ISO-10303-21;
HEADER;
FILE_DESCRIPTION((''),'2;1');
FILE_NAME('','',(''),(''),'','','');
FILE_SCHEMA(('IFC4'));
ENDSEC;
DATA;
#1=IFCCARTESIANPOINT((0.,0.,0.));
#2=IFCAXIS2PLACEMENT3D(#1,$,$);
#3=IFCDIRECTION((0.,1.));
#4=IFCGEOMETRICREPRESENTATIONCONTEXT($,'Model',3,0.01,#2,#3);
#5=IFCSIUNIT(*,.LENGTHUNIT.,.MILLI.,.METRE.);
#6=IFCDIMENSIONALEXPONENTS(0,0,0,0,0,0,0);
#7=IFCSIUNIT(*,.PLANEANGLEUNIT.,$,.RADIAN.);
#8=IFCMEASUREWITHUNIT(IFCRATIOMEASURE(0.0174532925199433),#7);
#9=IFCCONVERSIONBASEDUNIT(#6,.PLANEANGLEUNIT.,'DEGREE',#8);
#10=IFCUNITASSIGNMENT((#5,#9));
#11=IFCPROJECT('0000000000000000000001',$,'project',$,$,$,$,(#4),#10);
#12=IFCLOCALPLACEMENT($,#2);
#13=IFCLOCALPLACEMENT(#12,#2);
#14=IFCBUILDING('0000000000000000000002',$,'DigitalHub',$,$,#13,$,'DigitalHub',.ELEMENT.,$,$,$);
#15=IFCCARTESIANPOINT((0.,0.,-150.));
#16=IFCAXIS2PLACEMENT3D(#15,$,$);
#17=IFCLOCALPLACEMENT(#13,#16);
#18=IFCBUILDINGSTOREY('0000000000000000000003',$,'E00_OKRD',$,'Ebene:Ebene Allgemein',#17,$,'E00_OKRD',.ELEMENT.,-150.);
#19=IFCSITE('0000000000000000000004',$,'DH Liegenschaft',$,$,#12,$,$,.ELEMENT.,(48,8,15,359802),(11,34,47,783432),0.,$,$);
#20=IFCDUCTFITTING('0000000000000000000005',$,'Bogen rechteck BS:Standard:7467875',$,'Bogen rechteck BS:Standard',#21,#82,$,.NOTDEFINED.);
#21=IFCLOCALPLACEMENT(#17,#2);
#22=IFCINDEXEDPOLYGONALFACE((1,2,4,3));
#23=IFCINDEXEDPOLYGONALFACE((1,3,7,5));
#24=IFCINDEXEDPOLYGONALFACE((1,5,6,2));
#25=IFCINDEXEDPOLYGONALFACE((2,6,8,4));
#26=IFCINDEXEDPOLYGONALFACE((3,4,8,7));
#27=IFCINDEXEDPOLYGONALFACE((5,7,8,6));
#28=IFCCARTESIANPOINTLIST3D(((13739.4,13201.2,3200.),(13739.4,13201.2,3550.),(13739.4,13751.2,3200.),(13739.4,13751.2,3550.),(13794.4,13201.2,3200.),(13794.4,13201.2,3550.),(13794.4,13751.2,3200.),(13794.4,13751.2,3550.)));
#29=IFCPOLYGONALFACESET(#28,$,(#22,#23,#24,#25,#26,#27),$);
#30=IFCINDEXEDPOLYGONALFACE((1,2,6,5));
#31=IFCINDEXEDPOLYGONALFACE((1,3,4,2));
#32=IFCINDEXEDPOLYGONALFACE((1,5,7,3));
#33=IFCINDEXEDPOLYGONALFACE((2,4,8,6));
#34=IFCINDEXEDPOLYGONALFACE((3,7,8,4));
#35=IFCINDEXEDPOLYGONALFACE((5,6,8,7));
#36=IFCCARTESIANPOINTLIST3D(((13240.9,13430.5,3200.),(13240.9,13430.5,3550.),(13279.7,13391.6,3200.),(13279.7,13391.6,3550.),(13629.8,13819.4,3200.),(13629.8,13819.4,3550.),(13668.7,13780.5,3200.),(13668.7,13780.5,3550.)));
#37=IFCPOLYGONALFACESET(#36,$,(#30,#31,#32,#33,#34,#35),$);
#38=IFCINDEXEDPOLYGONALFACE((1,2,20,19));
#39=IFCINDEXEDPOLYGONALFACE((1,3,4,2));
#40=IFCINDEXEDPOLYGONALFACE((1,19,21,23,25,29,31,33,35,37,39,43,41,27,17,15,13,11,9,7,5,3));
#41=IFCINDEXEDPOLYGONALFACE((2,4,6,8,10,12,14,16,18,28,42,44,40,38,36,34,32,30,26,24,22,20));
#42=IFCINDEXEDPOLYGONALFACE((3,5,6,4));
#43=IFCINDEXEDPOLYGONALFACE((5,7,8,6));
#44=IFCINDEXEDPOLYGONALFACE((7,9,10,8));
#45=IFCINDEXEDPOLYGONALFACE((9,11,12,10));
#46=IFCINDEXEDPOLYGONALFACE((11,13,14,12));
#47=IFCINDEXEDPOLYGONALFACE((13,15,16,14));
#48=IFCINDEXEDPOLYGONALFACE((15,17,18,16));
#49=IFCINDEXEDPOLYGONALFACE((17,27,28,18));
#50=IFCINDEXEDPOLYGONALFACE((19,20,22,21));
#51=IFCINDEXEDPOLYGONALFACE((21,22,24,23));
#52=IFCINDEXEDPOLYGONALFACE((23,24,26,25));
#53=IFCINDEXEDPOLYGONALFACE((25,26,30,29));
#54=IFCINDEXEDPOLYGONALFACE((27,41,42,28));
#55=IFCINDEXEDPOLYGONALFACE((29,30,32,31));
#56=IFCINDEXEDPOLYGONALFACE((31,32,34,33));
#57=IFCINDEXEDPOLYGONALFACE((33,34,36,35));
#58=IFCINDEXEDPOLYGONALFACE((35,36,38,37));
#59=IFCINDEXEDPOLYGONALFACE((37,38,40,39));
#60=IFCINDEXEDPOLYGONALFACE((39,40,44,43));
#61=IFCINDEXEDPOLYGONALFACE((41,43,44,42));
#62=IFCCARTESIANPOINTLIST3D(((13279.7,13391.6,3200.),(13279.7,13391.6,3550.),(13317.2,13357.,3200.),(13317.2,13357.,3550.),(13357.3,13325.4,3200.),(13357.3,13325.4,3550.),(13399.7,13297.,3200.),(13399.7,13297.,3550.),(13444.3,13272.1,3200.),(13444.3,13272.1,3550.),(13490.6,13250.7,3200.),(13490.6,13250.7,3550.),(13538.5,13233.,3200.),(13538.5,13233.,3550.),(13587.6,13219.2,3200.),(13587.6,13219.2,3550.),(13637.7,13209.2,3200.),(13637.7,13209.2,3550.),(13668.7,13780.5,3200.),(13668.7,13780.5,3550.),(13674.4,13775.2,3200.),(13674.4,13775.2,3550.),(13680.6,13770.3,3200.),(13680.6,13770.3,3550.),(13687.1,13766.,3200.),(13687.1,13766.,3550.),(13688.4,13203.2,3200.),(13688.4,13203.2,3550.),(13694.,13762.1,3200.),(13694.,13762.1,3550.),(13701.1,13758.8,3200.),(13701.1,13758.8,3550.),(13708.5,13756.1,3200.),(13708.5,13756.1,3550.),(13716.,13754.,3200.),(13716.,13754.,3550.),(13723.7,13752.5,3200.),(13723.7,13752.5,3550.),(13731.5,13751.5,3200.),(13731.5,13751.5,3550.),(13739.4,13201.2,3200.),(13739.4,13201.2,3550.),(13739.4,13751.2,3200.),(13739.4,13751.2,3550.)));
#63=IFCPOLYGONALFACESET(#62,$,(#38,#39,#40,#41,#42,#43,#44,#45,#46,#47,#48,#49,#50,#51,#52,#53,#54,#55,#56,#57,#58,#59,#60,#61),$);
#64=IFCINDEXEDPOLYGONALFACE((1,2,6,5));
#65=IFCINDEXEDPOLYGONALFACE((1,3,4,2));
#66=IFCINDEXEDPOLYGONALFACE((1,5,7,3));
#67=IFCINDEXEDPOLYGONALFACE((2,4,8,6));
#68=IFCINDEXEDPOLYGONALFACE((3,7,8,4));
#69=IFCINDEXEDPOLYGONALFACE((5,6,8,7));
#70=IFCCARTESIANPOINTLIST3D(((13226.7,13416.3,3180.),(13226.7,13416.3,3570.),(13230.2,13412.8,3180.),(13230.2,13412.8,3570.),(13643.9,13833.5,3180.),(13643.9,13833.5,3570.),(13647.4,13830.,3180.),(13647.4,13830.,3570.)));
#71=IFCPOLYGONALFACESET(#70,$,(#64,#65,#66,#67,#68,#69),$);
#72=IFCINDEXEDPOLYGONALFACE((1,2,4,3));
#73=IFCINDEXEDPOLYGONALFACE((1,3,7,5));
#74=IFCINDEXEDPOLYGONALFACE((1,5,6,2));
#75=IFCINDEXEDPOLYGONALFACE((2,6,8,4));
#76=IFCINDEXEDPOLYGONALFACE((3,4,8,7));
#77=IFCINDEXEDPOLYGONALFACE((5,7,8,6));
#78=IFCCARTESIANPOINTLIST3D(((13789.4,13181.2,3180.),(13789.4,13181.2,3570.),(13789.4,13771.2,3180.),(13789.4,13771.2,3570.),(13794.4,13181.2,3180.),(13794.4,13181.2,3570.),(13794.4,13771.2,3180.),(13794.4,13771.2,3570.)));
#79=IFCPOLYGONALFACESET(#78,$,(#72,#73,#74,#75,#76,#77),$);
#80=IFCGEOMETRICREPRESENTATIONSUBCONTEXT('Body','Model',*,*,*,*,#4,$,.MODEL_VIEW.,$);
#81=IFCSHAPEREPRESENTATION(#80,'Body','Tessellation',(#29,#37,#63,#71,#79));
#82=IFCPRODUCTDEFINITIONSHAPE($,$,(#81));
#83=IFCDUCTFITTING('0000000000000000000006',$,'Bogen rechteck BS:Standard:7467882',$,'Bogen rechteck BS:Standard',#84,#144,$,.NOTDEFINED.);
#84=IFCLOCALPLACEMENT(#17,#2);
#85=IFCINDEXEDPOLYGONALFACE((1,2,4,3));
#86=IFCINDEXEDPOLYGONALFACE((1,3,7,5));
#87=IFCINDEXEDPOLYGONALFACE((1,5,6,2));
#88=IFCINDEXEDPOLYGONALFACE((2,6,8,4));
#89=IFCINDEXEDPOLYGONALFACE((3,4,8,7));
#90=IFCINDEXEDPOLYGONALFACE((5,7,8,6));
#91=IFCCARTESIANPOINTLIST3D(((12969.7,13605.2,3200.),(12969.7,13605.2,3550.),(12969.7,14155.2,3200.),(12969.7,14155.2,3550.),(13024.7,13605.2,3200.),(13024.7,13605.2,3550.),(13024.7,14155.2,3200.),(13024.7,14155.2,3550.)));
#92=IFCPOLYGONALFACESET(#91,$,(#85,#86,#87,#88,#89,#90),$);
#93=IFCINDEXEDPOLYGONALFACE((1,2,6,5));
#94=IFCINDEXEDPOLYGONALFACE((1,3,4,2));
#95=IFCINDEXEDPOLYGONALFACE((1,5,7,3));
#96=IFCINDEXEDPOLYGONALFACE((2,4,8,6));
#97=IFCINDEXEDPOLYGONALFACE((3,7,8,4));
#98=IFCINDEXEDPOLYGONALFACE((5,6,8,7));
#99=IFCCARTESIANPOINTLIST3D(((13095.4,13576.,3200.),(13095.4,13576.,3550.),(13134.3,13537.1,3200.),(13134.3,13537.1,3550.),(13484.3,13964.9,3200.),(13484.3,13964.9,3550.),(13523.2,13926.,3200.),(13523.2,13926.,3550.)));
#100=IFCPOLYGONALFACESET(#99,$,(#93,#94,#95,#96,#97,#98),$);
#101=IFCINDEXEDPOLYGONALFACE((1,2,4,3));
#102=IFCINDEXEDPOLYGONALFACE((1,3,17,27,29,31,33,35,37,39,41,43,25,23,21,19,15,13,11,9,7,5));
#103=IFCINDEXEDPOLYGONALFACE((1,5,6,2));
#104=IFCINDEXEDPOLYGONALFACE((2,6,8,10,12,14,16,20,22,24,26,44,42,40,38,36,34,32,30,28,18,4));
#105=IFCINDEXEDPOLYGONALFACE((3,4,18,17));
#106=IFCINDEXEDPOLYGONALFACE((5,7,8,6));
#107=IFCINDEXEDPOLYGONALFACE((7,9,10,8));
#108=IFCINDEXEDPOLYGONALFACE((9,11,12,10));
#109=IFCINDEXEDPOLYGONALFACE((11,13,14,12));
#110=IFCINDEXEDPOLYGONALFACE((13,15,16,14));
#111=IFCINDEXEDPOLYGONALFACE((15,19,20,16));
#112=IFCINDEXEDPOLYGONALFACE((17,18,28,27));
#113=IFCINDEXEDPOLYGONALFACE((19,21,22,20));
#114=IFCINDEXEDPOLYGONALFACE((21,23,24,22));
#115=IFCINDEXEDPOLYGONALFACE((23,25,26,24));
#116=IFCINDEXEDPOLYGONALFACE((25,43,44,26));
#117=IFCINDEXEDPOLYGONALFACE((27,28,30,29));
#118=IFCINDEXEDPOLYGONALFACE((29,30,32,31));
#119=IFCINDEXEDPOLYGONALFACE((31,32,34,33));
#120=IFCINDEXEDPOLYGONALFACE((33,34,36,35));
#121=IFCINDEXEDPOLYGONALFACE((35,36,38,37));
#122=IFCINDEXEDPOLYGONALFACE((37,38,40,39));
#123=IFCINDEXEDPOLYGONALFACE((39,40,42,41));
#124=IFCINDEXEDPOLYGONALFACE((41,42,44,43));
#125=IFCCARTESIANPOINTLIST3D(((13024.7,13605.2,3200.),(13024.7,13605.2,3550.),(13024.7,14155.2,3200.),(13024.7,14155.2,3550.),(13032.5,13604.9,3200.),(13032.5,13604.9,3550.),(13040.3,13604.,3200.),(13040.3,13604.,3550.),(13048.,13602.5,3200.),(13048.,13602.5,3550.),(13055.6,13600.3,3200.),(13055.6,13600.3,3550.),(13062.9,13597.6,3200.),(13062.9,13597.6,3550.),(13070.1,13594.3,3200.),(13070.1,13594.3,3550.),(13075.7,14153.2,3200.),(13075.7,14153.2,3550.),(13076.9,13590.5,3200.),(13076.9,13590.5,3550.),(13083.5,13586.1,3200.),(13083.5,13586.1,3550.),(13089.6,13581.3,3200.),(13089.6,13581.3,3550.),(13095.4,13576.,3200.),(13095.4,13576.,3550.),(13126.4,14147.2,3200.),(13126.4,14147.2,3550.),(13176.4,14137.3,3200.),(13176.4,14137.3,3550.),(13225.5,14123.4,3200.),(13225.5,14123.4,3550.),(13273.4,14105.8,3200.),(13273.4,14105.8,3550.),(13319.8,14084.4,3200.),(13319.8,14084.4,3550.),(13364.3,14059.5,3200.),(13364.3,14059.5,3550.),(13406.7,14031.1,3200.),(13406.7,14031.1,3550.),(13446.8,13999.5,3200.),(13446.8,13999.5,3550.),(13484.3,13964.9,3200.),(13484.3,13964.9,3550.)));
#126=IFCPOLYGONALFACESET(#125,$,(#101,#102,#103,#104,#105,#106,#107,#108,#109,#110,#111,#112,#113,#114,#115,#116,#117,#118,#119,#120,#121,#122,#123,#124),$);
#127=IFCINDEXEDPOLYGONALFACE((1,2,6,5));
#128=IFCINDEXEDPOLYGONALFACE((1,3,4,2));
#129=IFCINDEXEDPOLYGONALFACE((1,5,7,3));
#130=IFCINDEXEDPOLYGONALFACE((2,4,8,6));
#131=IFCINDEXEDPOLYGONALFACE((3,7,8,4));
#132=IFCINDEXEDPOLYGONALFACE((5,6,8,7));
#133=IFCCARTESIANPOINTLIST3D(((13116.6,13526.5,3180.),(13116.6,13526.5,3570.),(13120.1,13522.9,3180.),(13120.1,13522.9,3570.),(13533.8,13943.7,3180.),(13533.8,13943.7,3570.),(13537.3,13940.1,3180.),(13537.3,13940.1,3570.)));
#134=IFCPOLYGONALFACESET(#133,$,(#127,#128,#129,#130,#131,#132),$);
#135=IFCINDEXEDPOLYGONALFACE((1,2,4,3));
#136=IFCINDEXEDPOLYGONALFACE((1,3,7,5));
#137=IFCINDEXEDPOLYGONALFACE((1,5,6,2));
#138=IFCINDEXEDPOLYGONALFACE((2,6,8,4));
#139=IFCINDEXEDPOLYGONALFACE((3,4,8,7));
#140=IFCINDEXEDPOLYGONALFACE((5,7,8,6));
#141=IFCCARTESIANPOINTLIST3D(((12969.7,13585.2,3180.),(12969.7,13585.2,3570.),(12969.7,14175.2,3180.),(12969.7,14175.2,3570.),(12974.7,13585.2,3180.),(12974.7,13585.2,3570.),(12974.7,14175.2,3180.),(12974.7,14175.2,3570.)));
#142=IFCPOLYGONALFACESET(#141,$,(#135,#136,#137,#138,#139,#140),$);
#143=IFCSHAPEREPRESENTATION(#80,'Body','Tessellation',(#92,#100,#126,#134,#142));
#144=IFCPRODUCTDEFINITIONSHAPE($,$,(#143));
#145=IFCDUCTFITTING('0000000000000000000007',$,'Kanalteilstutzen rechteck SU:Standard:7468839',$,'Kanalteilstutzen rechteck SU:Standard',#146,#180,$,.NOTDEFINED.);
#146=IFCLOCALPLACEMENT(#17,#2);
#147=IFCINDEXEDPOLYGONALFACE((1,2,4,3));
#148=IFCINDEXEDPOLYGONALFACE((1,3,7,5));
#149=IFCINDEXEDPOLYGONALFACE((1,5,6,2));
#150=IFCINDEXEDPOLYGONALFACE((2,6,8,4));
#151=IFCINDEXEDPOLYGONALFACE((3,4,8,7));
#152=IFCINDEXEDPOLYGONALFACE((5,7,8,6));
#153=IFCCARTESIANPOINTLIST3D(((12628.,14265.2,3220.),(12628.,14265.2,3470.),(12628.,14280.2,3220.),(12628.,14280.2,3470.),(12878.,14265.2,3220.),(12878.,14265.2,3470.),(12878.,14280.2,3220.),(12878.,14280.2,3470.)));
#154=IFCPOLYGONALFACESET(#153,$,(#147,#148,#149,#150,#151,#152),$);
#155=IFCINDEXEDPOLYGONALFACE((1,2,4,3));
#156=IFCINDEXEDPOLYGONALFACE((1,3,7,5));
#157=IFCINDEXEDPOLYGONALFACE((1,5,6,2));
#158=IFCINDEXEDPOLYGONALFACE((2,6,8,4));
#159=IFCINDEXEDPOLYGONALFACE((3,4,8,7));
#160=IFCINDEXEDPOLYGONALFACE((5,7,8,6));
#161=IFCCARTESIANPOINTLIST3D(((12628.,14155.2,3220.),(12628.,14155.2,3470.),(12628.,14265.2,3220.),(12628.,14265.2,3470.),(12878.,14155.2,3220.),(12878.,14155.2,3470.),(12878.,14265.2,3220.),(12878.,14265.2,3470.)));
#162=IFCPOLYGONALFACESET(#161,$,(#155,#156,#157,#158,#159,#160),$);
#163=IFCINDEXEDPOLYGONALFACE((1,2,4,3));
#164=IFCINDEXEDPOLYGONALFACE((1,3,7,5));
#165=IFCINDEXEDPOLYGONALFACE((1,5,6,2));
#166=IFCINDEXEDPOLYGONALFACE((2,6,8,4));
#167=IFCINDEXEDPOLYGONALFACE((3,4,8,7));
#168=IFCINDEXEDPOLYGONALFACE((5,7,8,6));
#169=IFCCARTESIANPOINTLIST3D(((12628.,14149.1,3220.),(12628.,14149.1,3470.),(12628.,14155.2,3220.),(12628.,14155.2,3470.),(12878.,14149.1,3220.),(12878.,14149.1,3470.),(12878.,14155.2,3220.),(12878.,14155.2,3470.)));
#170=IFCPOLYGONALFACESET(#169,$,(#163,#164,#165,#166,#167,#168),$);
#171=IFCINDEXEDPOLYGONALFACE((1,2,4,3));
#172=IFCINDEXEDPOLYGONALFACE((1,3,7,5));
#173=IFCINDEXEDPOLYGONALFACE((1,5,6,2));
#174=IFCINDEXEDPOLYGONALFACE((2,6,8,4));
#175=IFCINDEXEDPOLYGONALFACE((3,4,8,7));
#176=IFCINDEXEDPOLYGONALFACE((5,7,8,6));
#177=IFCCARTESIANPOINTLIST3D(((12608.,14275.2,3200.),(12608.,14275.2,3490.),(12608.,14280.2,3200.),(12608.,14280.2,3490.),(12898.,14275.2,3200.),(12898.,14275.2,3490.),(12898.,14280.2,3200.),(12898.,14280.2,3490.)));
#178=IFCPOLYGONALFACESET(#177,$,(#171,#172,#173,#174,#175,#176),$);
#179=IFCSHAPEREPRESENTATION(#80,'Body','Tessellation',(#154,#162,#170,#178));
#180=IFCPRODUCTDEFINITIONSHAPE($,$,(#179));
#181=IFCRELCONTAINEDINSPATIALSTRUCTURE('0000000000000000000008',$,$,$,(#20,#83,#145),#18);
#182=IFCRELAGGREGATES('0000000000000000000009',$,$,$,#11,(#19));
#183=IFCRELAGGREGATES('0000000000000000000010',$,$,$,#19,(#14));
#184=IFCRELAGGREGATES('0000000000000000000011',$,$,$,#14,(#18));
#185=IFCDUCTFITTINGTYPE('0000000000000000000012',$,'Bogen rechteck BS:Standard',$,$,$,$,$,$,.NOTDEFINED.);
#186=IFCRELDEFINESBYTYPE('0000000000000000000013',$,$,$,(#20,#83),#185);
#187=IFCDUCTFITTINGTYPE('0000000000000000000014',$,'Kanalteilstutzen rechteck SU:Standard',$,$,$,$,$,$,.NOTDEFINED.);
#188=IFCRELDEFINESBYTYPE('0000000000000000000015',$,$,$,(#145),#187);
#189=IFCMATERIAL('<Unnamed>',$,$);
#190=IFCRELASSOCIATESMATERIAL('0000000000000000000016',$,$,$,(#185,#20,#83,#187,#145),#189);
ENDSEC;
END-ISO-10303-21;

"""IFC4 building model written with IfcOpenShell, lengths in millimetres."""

from ifc_helpers import new_model, entity, si_unit, converted_unit, direction, frame, origin, place, context, subcontext, project, spatial, indexed_curve, outline, extrude, source, transform, mapped, material, type_object, type_shapes, element, save


model = new_model("IFC4")

# Units and contexts
model_context = context("Model", 3, precision=0.01, world=origin(), true_north=direction((0.0, 1.0)))
body_context = subcontext(model_context, "Body", "Model", "MODEL_VIEW")
ifc_project = project(units=[si_unit("LENGTHUNIT", "METRE", prefix="MILLI"), converted_unit("PLANEANGLEUNIT", "DEGREE", entity("IfcRatioMeasure", 0.0174532925199433), si_unit("PLANEANGLEUNIT", "RADIAN"), dimensions=[0, 0, 0, 0, 0, 0, 0])], contexts=[model_context])

# Site, building, storey
site_placement = place(None, origin())
site = spatial("IfcSite", under=ifc_project, at=site_placement, Name="DH Liegenschaft", CompositionType="ELEMENT", RefLatitude=(48, 8, 15, 359802), RefLongitude=(11, 34, 47, 783432), RefElevation=0.0)
building_placement = place(site_placement, origin())
building = spatial("IfcBuilding", under=site, at=building_placement, Name="DigitalHub", LongName="DigitalHub", CompositionType="ELEMENT")
storey_placement = place(building_placement, frame((0.0, 0.0, -150.0)))
storey = spatial("IfcBuildingStorey", under=building, at=storey_placement, Name="E00_OKRD", ObjectType="Ebene:Ebene Allgemein", LongName="E00_OKRD", CompositionType="ELEMENT", Elevation=-150.0)

# Shared definitions
ifc_material_1 = material(Name="<Unnamed>")

# Duct fittings
duct_fitting_type_1 = type_object("IfcDuctFittingType", Name="Bogen rechteck BS:Standard", PredefinedType="NOTDEFINED", material=ifc_material_1)
shared_shape_1 = source(origin(), body_context, "Body", "SweptSolid", [
    extrude(outline(indexed_curve([(-27.5, -275.0), (27.5, -275.0), (27.5, 275.0), (-27.5, 275.0), (-27.5, -275.0)], self_intersect=False)), frame((129.3, 129.3, -175.0), z_axis=(0.0, 0.0, 1.0), x_axis=(0.707107, 0.707107, 0.0)), (0.0, 0.0, 1.0), 350.0),
    extrude(outline(indexed_curve([(-275.0, -27.5), (275.0, -27.5), (275.0, 27.5), (-275.0, 27.5), (-275.0, -27.5)], self_intersect=False)), frame((-182.8, 0.0, -175.0), z_axis=(0.0, 0.0, 1.0), x_axis=(0.0, -1.0, 0.0)), (0.0, 0.0, 1.0), 350.0),
    extrude(outline(indexed_curve([(-329.9, -132.6), (220.1, -132.6), (220.4, -124.7), (221.3, -116.9), (222.8, -109.2), (225.0, -101.7), (227.7, -94.3), (231.0, -87.2), (234.8, -80.3), (239.2, -73.8), (244.0, -67.6), (249.4, -61.9), (-139.5, 327.0), (-174.2, 289.6), (-205.8, 249.5), (-234.1, 207.0), (-259.1, 162.5), (-280.4, 116.2), (-298.1, 68.3), (-312.0, 19.2), (-321.9, -30.9), (-327.9, -81.6), (-329.9, -132.6)], self_intersect=False)), frame((-22.7, 54.9, -175.0), z_axis=(0.0, 0.0, 1.0), x_axis=(-0.707107, 0.707107, 0.0)), (0.0, 0.0, 1.0), 350.0),
    extrude(outline(indexed_curve([(-2.5, -295.0), (2.5, -295.0), (2.5, 295.0), (-2.5, 295.0), (-2.5, -295.0)], self_intersect=False)), frame((-207.8, 0.0, -195.0)), (0.0, 0.0, 1.0), 390.0),
    extrude(outline(indexed_curve([(-2.5, -295.0), (2.5, -295.0), (2.5, 295.0), (-2.5, 295.0), (-2.5, -295.0)], self_intersect=False)), frame((147.0, 147.0, -195.0), z_axis=(0.0, 0.0, 1.0), x_axis=(0.707107, 0.707107, 0.0)), (0.0, 0.0, 1.0), 390.0),
])
type_shapes(duct_fitting_type_1, [shared_shape_1])
for number, where, z_axis, x_axis, name in (
    (1, (13584.0, 13476.2, 3375.0), (0.0, 0.0, 1.0), (0.707107, -0.707107, 0.0), "Bogen rechteck BS:Standard:7467875"),
    (2, (13180.0, 13880.2, 3375.0), (0.0, 0.0, 1.0), (-0.707107, 0.707107, 0.0), "Bogen rechteck BS:Standard:7467882"),
):
    element("IfcDuctFitting", number, at=place(storey_placement, frame(where, z_axis=z_axis, x_axis=x_axis)), inside=storey, type_object=duct_fitting_type_1, material=ifc_material_1, Name=name, ObjectType="Bogen rechteck BS:Standard", PredefinedType="NOTDEFINED", context=body_context, shape_type="MappedRepresentation", body=[
        mapped(shared_shape_1, transform((0.0, 0.0, 0.0), scale=1.0)),
    ])
duct_fitting_type_2 = type_object("IfcDuctFittingType", Name="Kanalteilstutzen rechteck SU:Standard", PredefinedType="NOTDEFINED", material=ifc_material_1)
shared_shape_2 = source(origin(), body_context, "Body", "SweptSolid", [
    extrude(outline(indexed_curve([(-7.5, -125.0), (7.5, -125.0), (7.5, 125.0), (-7.5, 125.0), (-7.5, -125.0)], self_intersect=False)), frame((117.5, 0.0, -125.0)), (0.0, 0.0, 1.0), 250.0),
    extrude(outline(indexed_curve([(-55.0, -125.0), (55.0, -125.0), (55.0, 125.0), (-55.0, 125.0), (-55.0, -125.0)], self_intersect=False)), frame((55.0, 0.0, -125.0)), (0.0, 0.0, 1.0), 250.0),
    extrude(outline(indexed_curve([(-3.0, -125.0), (3.0, -125.0), (3.0, 125.0), (-3.0, 125.0), (-3.0, -125.0)], self_intersect=False)), frame((-3.0, 0.0, -125.0)), (0.0, 0.0, 1.0), 250.0),
    extrude(outline(indexed_curve([(-2.5, -145.0), (2.5, -145.0), (2.5, 145.0), (-2.5, 145.0), (-2.5, -145.0)], self_intersect=False)), frame((122.5, 0.0, -145.0)), (0.0, 0.0, 1.0), 290.0),
])
type_shapes(duct_fitting_type_2, [shared_shape_2])
duct_fitting_1_placement = place(storey_placement, frame((12753.0, 14155.2, 3345.0), z_axis=(0.0, 0.0, -1.0), x_axis=(0.0, 1.0, 0.0)))
element("IfcDuctFitting", 3, at=duct_fitting_1_placement, inside=storey, type_object=duct_fitting_type_2, material=ifc_material_1, Name="Kanalteilstutzen rechteck SU:Standard:7468839", ObjectType="Kanalteilstutzen rechteck SU:Standard", PredefinedType="NOTDEFINED", context=body_context, shape_type="MappedRepresentation", body=[
    mapped(shared_shape_2, transform((0.0, 0.0, 0.0), scale=1.0)),
])

save(model, "model.ifc")
